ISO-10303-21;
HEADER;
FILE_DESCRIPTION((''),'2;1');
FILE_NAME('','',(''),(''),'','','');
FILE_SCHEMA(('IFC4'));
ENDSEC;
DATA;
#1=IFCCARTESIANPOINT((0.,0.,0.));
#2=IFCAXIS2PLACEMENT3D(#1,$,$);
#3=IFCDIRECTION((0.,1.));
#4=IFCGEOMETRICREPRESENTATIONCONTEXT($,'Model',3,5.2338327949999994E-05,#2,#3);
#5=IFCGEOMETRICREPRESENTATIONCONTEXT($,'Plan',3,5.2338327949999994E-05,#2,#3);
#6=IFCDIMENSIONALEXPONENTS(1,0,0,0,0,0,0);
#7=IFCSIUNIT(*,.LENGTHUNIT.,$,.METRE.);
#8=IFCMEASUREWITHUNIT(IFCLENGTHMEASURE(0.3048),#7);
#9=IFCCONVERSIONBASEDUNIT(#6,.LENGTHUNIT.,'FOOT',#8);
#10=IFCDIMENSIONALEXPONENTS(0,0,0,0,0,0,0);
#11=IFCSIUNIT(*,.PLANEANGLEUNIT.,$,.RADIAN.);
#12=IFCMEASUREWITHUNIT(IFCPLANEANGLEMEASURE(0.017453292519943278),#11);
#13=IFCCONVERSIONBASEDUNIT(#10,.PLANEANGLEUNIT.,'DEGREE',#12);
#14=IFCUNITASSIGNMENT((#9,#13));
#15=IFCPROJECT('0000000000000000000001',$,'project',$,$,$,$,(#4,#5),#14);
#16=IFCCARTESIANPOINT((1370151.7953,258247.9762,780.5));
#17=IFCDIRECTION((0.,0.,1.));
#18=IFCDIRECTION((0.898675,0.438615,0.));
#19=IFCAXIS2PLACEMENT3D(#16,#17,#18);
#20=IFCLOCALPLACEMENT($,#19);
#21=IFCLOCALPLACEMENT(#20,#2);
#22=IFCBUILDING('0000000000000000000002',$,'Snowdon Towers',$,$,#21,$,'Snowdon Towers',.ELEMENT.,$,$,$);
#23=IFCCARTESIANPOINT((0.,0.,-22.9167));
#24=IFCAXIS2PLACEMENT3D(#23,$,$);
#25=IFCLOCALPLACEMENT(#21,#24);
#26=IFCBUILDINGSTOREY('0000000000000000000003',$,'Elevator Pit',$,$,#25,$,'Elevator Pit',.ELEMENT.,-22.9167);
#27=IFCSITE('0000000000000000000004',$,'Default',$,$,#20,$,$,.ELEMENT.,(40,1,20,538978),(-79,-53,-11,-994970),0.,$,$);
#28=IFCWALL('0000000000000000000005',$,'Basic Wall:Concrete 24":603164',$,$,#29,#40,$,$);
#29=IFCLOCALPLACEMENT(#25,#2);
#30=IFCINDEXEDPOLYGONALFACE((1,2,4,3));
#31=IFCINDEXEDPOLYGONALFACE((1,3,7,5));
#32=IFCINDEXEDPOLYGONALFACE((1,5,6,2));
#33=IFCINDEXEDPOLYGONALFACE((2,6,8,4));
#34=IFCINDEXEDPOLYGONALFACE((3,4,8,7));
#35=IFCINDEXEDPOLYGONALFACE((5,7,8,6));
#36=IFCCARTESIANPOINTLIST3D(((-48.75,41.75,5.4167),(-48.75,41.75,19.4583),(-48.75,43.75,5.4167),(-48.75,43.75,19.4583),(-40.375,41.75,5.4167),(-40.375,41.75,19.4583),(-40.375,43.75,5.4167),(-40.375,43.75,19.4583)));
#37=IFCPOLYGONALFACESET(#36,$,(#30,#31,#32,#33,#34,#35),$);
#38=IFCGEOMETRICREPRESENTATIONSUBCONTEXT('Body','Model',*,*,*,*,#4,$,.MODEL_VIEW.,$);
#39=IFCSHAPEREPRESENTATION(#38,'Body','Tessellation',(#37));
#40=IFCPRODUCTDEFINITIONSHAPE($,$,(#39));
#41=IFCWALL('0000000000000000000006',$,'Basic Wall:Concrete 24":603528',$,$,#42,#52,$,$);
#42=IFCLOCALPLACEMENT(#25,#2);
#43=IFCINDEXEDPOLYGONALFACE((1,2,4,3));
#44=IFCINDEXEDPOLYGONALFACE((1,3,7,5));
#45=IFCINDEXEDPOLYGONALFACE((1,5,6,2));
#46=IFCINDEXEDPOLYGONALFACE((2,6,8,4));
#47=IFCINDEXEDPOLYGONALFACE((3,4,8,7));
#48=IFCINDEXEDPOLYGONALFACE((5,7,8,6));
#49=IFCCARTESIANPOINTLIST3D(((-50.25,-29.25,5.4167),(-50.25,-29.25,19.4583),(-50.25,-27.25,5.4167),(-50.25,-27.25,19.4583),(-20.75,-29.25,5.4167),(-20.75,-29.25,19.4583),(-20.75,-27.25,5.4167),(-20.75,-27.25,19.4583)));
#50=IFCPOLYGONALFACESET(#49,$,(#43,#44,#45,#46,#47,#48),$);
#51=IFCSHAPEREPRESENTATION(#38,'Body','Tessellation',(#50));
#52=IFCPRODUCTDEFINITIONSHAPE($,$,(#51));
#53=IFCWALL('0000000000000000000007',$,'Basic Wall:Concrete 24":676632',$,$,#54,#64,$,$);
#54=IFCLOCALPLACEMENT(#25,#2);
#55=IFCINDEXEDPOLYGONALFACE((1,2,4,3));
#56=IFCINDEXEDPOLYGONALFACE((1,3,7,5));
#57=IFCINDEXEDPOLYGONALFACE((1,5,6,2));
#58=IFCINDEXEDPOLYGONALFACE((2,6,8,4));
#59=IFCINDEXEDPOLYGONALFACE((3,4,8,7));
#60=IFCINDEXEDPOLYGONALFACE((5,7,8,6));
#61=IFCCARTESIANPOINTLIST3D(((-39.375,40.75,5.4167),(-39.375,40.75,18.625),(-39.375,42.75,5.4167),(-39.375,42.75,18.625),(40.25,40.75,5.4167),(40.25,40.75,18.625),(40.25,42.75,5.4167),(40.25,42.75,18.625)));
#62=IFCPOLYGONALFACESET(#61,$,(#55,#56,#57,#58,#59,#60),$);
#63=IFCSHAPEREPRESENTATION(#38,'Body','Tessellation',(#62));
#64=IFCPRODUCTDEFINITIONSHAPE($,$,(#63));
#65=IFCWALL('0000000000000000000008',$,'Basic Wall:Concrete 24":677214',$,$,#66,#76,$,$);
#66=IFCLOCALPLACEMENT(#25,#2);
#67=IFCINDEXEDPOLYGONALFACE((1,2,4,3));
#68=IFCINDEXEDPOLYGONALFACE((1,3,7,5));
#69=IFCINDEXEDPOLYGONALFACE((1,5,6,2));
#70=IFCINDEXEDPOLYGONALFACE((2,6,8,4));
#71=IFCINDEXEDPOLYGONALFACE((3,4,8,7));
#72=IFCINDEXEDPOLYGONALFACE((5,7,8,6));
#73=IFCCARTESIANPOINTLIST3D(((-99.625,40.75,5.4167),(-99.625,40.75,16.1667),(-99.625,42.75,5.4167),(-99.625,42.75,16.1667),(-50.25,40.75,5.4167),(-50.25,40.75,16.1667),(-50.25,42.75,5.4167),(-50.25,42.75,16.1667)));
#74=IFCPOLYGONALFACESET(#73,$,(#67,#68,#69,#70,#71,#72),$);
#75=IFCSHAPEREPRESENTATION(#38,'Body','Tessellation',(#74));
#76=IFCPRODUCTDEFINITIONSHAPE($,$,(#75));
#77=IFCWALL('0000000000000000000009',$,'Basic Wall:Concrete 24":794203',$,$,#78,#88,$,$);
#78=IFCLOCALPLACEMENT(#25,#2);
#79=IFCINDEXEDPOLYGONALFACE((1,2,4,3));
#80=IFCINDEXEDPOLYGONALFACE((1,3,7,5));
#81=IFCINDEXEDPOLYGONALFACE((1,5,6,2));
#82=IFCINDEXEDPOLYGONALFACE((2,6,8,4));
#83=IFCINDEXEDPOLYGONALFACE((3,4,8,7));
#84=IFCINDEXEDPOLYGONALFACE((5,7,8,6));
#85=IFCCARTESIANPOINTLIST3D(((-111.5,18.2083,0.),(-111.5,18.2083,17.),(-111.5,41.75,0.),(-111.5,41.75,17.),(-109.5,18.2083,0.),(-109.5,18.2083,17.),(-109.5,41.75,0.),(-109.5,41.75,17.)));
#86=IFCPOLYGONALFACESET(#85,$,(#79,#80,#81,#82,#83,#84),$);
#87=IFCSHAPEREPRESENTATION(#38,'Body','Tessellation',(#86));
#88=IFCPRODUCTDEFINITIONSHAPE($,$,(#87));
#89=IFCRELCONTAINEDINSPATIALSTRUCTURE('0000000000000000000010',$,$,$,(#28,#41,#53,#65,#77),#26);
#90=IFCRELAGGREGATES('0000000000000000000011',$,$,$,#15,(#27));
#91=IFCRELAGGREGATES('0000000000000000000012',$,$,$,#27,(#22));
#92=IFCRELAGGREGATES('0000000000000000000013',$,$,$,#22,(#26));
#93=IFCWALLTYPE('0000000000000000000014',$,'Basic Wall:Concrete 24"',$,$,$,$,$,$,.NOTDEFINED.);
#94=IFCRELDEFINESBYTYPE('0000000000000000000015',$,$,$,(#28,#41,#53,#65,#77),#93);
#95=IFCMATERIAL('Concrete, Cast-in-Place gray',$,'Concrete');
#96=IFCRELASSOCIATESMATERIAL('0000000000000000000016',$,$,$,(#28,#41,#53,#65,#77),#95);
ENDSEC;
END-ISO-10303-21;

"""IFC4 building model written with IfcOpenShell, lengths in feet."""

from ifc_helpers import new_model, entity, si_unit, converted_unit, direction, frame, origin, place, context, subcontext, project, spatial, indexed_curve, outline, extrude, material, type_object, element, save


model = new_model("IFC4")

# Units and contexts
model_context = context("Model", 3, precision=5.2338327949999994e-05, world=origin(), true_north=direction((0.0, 1.0)))
plan_context = context("Plan", 3, precision=5.2338327949999994e-05, world=origin(), true_north=direction((0.0, 1.0)))
body_context = subcontext(model_context, "Body", "Model", "MODEL_VIEW")
ifc_project = project(units=[converted_unit("LENGTHUNIT", "FOOT", entity("IfcLengthMeasure", 0.3048), si_unit("LENGTHUNIT", "METRE"), dimensions=[1, 0, 0, 0, 0, 0, 0]), converted_unit("PLANEANGLEUNIT", "DEGREE", entity("IfcPlaneAngleMeasure", 0.017453292519943278), si_unit("PLANEANGLEUNIT", "RADIAN"), dimensions=[0, 0, 0, 0, 0, 0, 0])], contexts=[model_context, plan_context])

# Site, building, storey
site_placement = place(None, frame((1370151.7953, 258247.9762, 780.5), z_axis=(0.0, 0.0, 1.0), x_axis=(0.898675, 0.438615, 0.0)))
site = spatial("IfcSite", under=ifc_project, at=site_placement, Name="Default", CompositionType="ELEMENT", RefLatitude=(40, 1, 20, 538978), RefLongitude=(-79, -53, -11, -994970), RefElevation=0.0)
building_placement = place(site_placement, origin())
building = spatial("IfcBuilding", under=site, at=building_placement, Name="Snowdon Towers", LongName="Snowdon Towers", CompositionType="ELEMENT")
storey_placement = place(building_placement, frame((0.0, 0.0, -22.9167)))
storey = spatial("IfcBuildingStorey", under=building, at=storey_placement, Name="Elevator Pit", LongName="Elevator Pit", CompositionType="ELEMENT", Elevation=-22.9167)

# Shared definitions
ifc_material = material(Name="Concrete, Cast-in-Place gray", Category="Concrete")

# Walls
wall_type_1 = type_object("IfcWallType", Name="Basic Wall:Concrete 24\"", PredefinedType="NOTDEFINED")
wall_1_placement = place(storey_placement, frame((-48.75, 42.75, 5.4167)))
element("IfcWall", 1, at=wall_1_placement, inside=storey, type_object=wall_type_1, material=ifc_material, Name="Basic Wall:Concrete 24\":603164", context=body_context, shape_type="SweptSolid", body=[
    extrude(outline(indexed_curve([(8.375, 1.0), (0.0, 1.0), (0.0, -1.0), (8.375, -1.0), (8.375, 1.0)], self_intersect=False)), origin(), (0.0, 0.0, 1.0), 14.0417),
])
wall_2_placement = place(storey_placement, frame((-50.25, -28.25, 5.4167)))
element("IfcWall", 2, at=wall_2_placement, inside=storey, type_object=wall_type_1, material=ifc_material, Name="Basic Wall:Concrete 24\":603528", context=body_context, shape_type="SweptSolid", body=[
    extrude(outline(indexed_curve([(29.5, 1.0), (0.0, 1.0), (0.0, -1.0), (29.5, -1.0), (29.5, 1.0)], self_intersect=False)), origin(), (0.0, 0.0, 1.0), 14.0417),
])
wall_3_placement = place(storey_placement, frame((-39.375, 41.75, 5.4167)))
element("IfcWall", 3, at=wall_3_placement, inside=storey, type_object=wall_type_1, material=ifc_material, Name="Basic Wall:Concrete 24\":676632", context=body_context, shape_type="SweptSolid", body=[
    extrude(outline(indexed_curve([(79.625, 1.0), (0.0, 1.0), (0.0, -1.0), (79.625, -1.0), (79.625, 1.0)], self_intersect=False)), origin(), (0.0, 0.0, 1.0), 13.2083),
])
wall_4_placement = place(storey_placement, frame((-99.625, 41.75, 5.4167)))
element("IfcWall", 4, at=wall_4_placement, inside=storey, type_object=wall_type_1, material=ifc_material, Name="Basic Wall:Concrete 24\":677214", context=body_context, shape_type="SweptSolid", body=[
    extrude(outline(indexed_curve([(49.375, 1.0), (0.0, 1.0), (0.0, -1.0), (49.375, -1.0), (49.375, 1.0)], self_intersect=False)), origin(), (0.0, 0.0, 1.0), 10.75),
])
wall_5_placement = place(storey_placement, frame((-110.5, 18.2083, 0.0), z_axis=(0.0, 0.0, 1.0), x_axis=(0.0, 1.0, 0.0)))
element("IfcWall", 5, at=wall_5_placement, inside=storey, type_object=wall_type_1, material=ifc_material, Name="Basic Wall:Concrete 24\":794203", context=body_context, shape_type="SweptSolid", body=[
    extrude(outline(indexed_curve([(23.5417, 1.0), (0.0, 1.0), (0.0, -1.0), (23.5417, -1.0), (23.5417, 1.0)], self_intersect=False)), origin(), (0.0, 0.0, 1.0), 17.0),
])

save(model, "model.ifc")
